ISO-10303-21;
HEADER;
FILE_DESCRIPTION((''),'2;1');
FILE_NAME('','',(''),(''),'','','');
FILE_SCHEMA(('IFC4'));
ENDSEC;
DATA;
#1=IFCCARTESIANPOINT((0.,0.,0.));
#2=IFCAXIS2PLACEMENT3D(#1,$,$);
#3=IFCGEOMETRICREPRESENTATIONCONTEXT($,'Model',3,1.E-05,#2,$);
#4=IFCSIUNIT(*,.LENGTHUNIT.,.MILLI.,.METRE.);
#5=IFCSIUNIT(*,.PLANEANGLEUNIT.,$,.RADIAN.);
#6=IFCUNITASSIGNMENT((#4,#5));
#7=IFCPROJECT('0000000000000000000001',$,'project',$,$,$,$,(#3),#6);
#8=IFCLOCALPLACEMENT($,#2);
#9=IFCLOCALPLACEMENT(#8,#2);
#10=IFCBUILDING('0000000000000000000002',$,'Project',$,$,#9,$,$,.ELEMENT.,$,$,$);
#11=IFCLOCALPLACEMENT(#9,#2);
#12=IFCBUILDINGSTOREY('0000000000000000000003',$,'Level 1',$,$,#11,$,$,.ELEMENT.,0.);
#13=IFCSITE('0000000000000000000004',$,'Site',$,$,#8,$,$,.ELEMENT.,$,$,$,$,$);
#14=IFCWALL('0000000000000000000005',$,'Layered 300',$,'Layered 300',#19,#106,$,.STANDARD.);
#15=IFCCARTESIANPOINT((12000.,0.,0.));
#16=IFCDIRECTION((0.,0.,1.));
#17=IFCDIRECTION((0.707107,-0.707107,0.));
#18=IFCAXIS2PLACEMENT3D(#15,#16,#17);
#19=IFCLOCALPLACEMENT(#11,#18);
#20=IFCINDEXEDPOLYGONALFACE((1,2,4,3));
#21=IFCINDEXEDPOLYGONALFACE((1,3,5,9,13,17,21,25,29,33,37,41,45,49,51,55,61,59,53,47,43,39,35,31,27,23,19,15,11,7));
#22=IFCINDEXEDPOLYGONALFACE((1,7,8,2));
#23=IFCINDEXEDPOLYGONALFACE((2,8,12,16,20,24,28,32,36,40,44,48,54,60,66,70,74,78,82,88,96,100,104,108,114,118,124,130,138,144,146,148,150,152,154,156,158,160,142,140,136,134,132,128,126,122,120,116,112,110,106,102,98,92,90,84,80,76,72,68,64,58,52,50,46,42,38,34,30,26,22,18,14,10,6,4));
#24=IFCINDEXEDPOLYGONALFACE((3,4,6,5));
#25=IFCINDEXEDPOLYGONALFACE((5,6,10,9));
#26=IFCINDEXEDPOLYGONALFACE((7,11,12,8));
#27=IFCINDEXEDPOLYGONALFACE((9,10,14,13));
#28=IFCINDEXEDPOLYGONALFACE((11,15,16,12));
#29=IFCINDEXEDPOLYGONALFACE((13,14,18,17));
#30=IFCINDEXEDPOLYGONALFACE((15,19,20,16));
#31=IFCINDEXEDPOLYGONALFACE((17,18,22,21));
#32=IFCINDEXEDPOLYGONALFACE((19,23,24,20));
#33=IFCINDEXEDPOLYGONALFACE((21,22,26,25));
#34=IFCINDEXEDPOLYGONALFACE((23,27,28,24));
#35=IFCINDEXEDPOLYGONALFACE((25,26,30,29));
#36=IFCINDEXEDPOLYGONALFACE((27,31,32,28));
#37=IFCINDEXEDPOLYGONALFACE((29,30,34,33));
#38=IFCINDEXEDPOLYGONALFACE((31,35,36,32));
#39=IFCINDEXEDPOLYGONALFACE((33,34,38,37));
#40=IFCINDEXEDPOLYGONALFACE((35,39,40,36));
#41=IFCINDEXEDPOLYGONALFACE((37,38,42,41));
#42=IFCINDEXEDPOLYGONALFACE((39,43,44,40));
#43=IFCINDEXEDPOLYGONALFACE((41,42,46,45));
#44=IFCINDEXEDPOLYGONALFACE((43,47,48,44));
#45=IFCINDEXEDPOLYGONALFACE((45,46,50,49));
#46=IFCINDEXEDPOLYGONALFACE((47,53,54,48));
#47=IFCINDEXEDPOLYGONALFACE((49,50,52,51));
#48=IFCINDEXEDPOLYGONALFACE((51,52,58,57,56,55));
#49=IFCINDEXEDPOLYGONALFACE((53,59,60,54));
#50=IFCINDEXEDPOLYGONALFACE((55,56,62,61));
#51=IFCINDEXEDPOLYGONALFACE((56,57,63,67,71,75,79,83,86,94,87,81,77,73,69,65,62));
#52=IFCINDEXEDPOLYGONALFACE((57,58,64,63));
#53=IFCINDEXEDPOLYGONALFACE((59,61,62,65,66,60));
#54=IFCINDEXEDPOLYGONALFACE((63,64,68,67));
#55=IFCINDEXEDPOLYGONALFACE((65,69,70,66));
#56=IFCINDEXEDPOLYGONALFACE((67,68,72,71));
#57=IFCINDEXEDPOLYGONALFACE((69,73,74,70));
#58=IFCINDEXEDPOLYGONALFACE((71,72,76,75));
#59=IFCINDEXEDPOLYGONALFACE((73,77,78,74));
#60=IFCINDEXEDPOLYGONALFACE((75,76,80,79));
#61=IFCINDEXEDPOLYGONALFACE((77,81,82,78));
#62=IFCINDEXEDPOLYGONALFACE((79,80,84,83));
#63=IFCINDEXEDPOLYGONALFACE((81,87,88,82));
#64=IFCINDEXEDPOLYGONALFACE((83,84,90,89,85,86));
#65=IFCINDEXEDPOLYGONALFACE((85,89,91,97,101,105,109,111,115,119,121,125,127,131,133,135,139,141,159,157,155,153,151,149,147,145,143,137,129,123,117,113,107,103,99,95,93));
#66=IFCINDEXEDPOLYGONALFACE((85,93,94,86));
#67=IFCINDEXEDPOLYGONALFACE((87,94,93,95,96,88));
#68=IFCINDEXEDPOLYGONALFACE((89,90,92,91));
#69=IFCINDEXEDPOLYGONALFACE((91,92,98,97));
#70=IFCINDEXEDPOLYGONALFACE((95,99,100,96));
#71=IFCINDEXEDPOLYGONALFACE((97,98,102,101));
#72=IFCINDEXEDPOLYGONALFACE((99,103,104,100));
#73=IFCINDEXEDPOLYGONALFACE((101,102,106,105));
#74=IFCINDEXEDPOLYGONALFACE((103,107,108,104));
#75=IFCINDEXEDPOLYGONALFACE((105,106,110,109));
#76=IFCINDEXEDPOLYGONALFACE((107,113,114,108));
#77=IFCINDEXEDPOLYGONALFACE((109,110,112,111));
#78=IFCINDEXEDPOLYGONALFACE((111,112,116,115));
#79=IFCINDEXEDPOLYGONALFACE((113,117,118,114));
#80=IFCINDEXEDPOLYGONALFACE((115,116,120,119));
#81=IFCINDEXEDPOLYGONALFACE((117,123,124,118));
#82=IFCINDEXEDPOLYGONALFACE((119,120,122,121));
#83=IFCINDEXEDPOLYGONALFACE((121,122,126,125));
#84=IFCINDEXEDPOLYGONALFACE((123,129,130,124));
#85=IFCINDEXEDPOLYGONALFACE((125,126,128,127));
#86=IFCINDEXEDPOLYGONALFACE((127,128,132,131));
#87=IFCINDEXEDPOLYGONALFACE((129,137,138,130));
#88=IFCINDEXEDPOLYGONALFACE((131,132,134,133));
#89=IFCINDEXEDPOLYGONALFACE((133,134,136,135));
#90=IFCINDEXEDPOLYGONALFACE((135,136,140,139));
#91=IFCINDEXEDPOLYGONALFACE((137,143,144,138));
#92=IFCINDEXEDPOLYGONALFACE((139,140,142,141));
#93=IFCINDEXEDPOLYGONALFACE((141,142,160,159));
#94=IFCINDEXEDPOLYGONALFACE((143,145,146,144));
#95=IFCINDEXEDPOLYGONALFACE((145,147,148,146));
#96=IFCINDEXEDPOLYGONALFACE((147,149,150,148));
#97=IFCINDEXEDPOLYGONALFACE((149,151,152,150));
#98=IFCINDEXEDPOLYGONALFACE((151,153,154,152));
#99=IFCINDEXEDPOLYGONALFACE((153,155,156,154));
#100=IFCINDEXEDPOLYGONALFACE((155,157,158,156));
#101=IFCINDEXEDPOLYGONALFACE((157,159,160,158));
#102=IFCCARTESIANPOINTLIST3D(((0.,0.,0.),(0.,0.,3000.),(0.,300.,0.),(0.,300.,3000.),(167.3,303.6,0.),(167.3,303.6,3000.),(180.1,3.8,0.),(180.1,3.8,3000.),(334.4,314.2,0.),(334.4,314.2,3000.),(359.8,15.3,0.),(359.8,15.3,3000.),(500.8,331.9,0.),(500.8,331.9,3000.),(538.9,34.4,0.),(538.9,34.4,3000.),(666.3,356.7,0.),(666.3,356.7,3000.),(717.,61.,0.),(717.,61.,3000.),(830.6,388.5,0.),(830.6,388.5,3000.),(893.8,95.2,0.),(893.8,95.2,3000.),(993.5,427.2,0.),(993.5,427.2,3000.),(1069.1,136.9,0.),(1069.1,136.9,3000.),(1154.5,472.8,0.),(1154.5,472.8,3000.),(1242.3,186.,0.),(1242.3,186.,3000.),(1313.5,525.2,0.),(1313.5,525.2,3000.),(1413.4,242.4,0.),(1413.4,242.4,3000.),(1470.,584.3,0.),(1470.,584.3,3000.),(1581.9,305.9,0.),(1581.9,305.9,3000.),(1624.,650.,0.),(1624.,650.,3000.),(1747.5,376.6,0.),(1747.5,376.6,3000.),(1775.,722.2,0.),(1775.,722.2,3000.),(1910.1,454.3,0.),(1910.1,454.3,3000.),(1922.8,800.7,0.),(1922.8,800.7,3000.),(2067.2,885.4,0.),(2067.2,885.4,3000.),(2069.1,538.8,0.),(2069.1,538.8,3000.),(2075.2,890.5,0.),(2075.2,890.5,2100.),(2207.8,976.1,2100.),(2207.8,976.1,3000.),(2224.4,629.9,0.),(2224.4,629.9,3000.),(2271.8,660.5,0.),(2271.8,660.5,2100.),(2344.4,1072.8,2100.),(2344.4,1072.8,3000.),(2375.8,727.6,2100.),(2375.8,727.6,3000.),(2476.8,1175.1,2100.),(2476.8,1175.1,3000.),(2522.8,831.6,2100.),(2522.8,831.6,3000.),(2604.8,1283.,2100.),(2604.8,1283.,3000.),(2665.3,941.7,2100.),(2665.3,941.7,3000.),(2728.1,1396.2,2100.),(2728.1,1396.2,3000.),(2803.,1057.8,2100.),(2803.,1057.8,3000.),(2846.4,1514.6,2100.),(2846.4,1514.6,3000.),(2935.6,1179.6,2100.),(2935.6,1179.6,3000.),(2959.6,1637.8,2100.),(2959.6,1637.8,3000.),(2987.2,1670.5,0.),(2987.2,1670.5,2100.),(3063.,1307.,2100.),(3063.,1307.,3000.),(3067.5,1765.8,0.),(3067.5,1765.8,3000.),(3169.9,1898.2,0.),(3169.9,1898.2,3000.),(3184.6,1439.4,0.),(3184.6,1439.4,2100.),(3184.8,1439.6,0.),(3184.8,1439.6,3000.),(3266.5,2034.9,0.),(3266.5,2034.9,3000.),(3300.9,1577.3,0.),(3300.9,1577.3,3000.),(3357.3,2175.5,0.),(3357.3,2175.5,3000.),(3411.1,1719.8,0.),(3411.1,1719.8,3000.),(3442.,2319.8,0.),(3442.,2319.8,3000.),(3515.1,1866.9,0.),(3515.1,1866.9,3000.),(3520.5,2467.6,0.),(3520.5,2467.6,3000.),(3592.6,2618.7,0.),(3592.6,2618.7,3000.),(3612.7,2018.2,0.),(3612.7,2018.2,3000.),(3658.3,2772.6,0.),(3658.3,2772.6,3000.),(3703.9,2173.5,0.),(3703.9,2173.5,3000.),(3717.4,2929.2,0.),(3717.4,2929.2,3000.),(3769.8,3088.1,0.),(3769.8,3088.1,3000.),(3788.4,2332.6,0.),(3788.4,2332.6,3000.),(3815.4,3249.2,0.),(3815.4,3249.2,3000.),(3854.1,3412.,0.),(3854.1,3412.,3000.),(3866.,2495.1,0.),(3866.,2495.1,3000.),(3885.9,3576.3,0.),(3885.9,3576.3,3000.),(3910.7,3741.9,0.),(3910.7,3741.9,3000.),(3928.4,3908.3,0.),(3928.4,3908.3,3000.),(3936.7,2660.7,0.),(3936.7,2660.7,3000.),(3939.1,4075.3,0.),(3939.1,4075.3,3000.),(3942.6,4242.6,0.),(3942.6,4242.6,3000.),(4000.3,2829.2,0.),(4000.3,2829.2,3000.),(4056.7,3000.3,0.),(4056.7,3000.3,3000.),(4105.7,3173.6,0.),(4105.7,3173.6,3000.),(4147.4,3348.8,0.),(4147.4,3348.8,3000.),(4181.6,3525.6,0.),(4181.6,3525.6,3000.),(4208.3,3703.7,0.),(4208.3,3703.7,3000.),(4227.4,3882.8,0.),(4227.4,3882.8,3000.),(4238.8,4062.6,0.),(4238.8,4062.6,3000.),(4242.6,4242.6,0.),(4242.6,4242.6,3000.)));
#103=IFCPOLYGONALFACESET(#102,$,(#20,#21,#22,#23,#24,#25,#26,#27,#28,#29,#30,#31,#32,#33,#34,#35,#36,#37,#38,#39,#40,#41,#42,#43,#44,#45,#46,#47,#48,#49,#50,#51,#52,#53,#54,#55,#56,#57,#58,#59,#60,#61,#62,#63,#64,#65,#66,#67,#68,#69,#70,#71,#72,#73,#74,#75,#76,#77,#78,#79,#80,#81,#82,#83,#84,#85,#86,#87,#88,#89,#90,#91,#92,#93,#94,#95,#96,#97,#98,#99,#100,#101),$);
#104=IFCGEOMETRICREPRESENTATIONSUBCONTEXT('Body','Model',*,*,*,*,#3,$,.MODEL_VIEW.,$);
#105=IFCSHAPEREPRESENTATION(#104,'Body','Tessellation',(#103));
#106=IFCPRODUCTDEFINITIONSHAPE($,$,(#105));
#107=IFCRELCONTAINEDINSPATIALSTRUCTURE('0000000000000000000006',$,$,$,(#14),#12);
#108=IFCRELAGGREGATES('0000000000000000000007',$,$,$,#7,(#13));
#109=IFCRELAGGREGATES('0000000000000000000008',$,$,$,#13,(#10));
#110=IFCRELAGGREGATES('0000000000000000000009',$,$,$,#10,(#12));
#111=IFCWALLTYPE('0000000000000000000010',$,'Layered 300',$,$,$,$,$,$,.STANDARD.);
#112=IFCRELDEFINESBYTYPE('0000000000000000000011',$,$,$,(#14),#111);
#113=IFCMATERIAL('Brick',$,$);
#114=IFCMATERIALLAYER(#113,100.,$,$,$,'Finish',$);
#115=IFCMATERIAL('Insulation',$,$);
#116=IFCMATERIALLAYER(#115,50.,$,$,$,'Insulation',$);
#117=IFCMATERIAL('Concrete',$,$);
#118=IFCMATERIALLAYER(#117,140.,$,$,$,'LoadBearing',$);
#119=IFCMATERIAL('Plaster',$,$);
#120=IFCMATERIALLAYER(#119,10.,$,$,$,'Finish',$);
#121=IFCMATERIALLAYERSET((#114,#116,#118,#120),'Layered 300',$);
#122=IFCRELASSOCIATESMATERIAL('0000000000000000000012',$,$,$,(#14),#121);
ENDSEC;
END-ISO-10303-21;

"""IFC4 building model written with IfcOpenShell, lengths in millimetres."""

from ifc_helpers import new_model, si_unit, frame, frame_2d, origin, place, context, subcontext, project, spatial, polyline, rectangle, outline, extrude, material, layer, layer_set, layer_usage, type_object, element, save


model = new_model("IFC4")

# Units and contexts
model_context = context("Model", 3, precision=1e-05, world=origin())
body_context = subcontext(model_context, "Body", "Model", "MODEL_VIEW")
ifc_project = project(units=[si_unit("LENGTHUNIT", "METRE", prefix="MILLI"), si_unit("PLANEANGLEUNIT", "RADIAN")], contexts=[model_context])

# Site, building, storey
site_placement = place(None, origin())
site = spatial("IfcSite", under=ifc_project, at=site_placement, Name="Site", CompositionType="ELEMENT")
building_placement = place(site_placement, origin())
building = spatial("IfcBuilding", under=site, at=building_placement, Name="Project", CompositionType="ELEMENT")
storey_placement = place(building_placement, origin())
storey = spatial("IfcBuildingStorey", under=building, at=storey_placement, Name="Level 1", CompositionType="ELEMENT", Elevation=0.0)

# Shared definitions
ifc_material_1 = material(Name="Brick")
ifc_layer_1 = layer(ifc_material_1, 100.0, Category="Finish")
ifc_material_2 = material(Name="Insulation")
ifc_layer_2 = layer(ifc_material_2, 50.0, Category="Insulation")
ifc_material_3 = material(Name="Concrete")
ifc_layer_3 = layer(ifc_material_3, 140.0, Category="LoadBearing")
ifc_material_4 = material(Name="Plaster")
ifc_layer_4 = layer(ifc_material_4, 10.0, Category="Finish")
ifc_layer_set = layer_set([ifc_layer_1, ifc_layer_2, ifc_layer_3, ifc_layer_4], Name="Layered 300")
wall_type_1 = type_object("IfcWallType", Name="Layered 300", PredefinedType="STANDARD")

# Wall, opening
ifc_layer_usage_1 = layer_usage(ifc_layer_set, "AXIS2", "NEGATIVE", 300.0)
wall_1_placement = place(storey_placement, frame((12000.0, 0.0, 0.0), z_axis=(0.0, 0.0, 1.0), x_axis=(0.707107, -0.707107, 0.0)))
wall_1 = element("IfcWall", 1, at=wall_1_placement, inside=storey, type_object=wall_type_1, material=ifc_layer_usage_1, Name="Layered 300", ObjectType="Layered 300", PredefinedType="STANDARD", context=body_context, shape_type="SweptSolid", body=[
    extrude(outline(polyline([(0.0, 0.0), (0.0, 300.0), (167.3, 303.6), (334.4, 314.2), (500.8, 331.9), (666.3, 356.7), (830.6, 388.5), (993.5, 427.2), (1154.5, 472.8), (1313.5, 525.2), (1470.0, 584.3), (1624.0, 650.0), (1775.0, 722.2), (1922.8, 800.7), (2067.2, 885.4), (2207.8, 976.1), (2344.4, 1072.8), (2476.8, 1175.1), (2604.8, 1283.0), (2728.1, 1396.2), (2846.4, 1514.6), (2959.6, 1637.8), (3067.5, 1765.8), (3169.9, 1898.2), (3266.5, 2034.9), (3357.3, 2175.5), (3442.0, 2319.8), (3520.5, 2467.6), (3592.6, 2618.7), (3658.3, 2772.6), (3717.4, 2929.2), (3769.8, 3088.1), (3815.4, 3249.2), (3854.1, 3412.0), (3885.9, 3576.3), (3910.7, 3741.9), (3928.4, 3908.3), (3939.1, 4075.3), (3942.6, 4242.6), (4242.6, 4242.6), (4238.8, 4062.6), (4227.4, 3882.8), (4208.3, 3703.7), (4181.6, 3525.6), (4147.4, 3348.8), (4105.7, 3173.6), (4056.7, 3000.3), (4000.3, 2829.2), (3936.7, 2660.7), (3866.0, 2495.1), (3788.4, 2332.6), (3703.9, 2173.5), (3612.7, 2018.2), (3515.1, 1866.9), (3411.1, 1719.8), (3300.9, 1577.3), (3184.8, 1439.6), (3063.0, 1307.0), (2935.6, 1179.6), (2803.0, 1057.8), (2665.3, 941.7), (2522.8, 831.6), (2375.8, 727.6), (2224.4, 629.9), (2069.1, 538.8), (1910.1, 454.3), (1747.5, 376.6), (1581.9, 305.9), (1413.4, 242.4), (1242.3, 186.0), (1069.1, 136.9), (893.8, 95.2), (717.0, 61.0), (538.9, 34.4), (359.8, 15.3), (180.1, 3.8), (0.0, 0.0)])), origin(), (0.0, 0.0, 1.0), 3000.0),
])
opening_1_placement = place(wall_1_placement, frame((2202.6, 741.5, 0.0), z_axis=(0.0, 0.0, 1.0), x_axis=(0.760245, 0.649637, 0.0)))
element("IfcOpeningElement", 2, at=opening_1_placement, cuts=wall_1, PredefinedType="OPENING", context=body_context, shape_type="SweptSolid", body=[
    extrude(rectangle(XDim=1200.0, YDim=411.8, at=frame_2d((600.0, 0.0))), origin(), (0.0, 0.0, 1.0), 2100.0),
])

save(model, "model.ifc")
